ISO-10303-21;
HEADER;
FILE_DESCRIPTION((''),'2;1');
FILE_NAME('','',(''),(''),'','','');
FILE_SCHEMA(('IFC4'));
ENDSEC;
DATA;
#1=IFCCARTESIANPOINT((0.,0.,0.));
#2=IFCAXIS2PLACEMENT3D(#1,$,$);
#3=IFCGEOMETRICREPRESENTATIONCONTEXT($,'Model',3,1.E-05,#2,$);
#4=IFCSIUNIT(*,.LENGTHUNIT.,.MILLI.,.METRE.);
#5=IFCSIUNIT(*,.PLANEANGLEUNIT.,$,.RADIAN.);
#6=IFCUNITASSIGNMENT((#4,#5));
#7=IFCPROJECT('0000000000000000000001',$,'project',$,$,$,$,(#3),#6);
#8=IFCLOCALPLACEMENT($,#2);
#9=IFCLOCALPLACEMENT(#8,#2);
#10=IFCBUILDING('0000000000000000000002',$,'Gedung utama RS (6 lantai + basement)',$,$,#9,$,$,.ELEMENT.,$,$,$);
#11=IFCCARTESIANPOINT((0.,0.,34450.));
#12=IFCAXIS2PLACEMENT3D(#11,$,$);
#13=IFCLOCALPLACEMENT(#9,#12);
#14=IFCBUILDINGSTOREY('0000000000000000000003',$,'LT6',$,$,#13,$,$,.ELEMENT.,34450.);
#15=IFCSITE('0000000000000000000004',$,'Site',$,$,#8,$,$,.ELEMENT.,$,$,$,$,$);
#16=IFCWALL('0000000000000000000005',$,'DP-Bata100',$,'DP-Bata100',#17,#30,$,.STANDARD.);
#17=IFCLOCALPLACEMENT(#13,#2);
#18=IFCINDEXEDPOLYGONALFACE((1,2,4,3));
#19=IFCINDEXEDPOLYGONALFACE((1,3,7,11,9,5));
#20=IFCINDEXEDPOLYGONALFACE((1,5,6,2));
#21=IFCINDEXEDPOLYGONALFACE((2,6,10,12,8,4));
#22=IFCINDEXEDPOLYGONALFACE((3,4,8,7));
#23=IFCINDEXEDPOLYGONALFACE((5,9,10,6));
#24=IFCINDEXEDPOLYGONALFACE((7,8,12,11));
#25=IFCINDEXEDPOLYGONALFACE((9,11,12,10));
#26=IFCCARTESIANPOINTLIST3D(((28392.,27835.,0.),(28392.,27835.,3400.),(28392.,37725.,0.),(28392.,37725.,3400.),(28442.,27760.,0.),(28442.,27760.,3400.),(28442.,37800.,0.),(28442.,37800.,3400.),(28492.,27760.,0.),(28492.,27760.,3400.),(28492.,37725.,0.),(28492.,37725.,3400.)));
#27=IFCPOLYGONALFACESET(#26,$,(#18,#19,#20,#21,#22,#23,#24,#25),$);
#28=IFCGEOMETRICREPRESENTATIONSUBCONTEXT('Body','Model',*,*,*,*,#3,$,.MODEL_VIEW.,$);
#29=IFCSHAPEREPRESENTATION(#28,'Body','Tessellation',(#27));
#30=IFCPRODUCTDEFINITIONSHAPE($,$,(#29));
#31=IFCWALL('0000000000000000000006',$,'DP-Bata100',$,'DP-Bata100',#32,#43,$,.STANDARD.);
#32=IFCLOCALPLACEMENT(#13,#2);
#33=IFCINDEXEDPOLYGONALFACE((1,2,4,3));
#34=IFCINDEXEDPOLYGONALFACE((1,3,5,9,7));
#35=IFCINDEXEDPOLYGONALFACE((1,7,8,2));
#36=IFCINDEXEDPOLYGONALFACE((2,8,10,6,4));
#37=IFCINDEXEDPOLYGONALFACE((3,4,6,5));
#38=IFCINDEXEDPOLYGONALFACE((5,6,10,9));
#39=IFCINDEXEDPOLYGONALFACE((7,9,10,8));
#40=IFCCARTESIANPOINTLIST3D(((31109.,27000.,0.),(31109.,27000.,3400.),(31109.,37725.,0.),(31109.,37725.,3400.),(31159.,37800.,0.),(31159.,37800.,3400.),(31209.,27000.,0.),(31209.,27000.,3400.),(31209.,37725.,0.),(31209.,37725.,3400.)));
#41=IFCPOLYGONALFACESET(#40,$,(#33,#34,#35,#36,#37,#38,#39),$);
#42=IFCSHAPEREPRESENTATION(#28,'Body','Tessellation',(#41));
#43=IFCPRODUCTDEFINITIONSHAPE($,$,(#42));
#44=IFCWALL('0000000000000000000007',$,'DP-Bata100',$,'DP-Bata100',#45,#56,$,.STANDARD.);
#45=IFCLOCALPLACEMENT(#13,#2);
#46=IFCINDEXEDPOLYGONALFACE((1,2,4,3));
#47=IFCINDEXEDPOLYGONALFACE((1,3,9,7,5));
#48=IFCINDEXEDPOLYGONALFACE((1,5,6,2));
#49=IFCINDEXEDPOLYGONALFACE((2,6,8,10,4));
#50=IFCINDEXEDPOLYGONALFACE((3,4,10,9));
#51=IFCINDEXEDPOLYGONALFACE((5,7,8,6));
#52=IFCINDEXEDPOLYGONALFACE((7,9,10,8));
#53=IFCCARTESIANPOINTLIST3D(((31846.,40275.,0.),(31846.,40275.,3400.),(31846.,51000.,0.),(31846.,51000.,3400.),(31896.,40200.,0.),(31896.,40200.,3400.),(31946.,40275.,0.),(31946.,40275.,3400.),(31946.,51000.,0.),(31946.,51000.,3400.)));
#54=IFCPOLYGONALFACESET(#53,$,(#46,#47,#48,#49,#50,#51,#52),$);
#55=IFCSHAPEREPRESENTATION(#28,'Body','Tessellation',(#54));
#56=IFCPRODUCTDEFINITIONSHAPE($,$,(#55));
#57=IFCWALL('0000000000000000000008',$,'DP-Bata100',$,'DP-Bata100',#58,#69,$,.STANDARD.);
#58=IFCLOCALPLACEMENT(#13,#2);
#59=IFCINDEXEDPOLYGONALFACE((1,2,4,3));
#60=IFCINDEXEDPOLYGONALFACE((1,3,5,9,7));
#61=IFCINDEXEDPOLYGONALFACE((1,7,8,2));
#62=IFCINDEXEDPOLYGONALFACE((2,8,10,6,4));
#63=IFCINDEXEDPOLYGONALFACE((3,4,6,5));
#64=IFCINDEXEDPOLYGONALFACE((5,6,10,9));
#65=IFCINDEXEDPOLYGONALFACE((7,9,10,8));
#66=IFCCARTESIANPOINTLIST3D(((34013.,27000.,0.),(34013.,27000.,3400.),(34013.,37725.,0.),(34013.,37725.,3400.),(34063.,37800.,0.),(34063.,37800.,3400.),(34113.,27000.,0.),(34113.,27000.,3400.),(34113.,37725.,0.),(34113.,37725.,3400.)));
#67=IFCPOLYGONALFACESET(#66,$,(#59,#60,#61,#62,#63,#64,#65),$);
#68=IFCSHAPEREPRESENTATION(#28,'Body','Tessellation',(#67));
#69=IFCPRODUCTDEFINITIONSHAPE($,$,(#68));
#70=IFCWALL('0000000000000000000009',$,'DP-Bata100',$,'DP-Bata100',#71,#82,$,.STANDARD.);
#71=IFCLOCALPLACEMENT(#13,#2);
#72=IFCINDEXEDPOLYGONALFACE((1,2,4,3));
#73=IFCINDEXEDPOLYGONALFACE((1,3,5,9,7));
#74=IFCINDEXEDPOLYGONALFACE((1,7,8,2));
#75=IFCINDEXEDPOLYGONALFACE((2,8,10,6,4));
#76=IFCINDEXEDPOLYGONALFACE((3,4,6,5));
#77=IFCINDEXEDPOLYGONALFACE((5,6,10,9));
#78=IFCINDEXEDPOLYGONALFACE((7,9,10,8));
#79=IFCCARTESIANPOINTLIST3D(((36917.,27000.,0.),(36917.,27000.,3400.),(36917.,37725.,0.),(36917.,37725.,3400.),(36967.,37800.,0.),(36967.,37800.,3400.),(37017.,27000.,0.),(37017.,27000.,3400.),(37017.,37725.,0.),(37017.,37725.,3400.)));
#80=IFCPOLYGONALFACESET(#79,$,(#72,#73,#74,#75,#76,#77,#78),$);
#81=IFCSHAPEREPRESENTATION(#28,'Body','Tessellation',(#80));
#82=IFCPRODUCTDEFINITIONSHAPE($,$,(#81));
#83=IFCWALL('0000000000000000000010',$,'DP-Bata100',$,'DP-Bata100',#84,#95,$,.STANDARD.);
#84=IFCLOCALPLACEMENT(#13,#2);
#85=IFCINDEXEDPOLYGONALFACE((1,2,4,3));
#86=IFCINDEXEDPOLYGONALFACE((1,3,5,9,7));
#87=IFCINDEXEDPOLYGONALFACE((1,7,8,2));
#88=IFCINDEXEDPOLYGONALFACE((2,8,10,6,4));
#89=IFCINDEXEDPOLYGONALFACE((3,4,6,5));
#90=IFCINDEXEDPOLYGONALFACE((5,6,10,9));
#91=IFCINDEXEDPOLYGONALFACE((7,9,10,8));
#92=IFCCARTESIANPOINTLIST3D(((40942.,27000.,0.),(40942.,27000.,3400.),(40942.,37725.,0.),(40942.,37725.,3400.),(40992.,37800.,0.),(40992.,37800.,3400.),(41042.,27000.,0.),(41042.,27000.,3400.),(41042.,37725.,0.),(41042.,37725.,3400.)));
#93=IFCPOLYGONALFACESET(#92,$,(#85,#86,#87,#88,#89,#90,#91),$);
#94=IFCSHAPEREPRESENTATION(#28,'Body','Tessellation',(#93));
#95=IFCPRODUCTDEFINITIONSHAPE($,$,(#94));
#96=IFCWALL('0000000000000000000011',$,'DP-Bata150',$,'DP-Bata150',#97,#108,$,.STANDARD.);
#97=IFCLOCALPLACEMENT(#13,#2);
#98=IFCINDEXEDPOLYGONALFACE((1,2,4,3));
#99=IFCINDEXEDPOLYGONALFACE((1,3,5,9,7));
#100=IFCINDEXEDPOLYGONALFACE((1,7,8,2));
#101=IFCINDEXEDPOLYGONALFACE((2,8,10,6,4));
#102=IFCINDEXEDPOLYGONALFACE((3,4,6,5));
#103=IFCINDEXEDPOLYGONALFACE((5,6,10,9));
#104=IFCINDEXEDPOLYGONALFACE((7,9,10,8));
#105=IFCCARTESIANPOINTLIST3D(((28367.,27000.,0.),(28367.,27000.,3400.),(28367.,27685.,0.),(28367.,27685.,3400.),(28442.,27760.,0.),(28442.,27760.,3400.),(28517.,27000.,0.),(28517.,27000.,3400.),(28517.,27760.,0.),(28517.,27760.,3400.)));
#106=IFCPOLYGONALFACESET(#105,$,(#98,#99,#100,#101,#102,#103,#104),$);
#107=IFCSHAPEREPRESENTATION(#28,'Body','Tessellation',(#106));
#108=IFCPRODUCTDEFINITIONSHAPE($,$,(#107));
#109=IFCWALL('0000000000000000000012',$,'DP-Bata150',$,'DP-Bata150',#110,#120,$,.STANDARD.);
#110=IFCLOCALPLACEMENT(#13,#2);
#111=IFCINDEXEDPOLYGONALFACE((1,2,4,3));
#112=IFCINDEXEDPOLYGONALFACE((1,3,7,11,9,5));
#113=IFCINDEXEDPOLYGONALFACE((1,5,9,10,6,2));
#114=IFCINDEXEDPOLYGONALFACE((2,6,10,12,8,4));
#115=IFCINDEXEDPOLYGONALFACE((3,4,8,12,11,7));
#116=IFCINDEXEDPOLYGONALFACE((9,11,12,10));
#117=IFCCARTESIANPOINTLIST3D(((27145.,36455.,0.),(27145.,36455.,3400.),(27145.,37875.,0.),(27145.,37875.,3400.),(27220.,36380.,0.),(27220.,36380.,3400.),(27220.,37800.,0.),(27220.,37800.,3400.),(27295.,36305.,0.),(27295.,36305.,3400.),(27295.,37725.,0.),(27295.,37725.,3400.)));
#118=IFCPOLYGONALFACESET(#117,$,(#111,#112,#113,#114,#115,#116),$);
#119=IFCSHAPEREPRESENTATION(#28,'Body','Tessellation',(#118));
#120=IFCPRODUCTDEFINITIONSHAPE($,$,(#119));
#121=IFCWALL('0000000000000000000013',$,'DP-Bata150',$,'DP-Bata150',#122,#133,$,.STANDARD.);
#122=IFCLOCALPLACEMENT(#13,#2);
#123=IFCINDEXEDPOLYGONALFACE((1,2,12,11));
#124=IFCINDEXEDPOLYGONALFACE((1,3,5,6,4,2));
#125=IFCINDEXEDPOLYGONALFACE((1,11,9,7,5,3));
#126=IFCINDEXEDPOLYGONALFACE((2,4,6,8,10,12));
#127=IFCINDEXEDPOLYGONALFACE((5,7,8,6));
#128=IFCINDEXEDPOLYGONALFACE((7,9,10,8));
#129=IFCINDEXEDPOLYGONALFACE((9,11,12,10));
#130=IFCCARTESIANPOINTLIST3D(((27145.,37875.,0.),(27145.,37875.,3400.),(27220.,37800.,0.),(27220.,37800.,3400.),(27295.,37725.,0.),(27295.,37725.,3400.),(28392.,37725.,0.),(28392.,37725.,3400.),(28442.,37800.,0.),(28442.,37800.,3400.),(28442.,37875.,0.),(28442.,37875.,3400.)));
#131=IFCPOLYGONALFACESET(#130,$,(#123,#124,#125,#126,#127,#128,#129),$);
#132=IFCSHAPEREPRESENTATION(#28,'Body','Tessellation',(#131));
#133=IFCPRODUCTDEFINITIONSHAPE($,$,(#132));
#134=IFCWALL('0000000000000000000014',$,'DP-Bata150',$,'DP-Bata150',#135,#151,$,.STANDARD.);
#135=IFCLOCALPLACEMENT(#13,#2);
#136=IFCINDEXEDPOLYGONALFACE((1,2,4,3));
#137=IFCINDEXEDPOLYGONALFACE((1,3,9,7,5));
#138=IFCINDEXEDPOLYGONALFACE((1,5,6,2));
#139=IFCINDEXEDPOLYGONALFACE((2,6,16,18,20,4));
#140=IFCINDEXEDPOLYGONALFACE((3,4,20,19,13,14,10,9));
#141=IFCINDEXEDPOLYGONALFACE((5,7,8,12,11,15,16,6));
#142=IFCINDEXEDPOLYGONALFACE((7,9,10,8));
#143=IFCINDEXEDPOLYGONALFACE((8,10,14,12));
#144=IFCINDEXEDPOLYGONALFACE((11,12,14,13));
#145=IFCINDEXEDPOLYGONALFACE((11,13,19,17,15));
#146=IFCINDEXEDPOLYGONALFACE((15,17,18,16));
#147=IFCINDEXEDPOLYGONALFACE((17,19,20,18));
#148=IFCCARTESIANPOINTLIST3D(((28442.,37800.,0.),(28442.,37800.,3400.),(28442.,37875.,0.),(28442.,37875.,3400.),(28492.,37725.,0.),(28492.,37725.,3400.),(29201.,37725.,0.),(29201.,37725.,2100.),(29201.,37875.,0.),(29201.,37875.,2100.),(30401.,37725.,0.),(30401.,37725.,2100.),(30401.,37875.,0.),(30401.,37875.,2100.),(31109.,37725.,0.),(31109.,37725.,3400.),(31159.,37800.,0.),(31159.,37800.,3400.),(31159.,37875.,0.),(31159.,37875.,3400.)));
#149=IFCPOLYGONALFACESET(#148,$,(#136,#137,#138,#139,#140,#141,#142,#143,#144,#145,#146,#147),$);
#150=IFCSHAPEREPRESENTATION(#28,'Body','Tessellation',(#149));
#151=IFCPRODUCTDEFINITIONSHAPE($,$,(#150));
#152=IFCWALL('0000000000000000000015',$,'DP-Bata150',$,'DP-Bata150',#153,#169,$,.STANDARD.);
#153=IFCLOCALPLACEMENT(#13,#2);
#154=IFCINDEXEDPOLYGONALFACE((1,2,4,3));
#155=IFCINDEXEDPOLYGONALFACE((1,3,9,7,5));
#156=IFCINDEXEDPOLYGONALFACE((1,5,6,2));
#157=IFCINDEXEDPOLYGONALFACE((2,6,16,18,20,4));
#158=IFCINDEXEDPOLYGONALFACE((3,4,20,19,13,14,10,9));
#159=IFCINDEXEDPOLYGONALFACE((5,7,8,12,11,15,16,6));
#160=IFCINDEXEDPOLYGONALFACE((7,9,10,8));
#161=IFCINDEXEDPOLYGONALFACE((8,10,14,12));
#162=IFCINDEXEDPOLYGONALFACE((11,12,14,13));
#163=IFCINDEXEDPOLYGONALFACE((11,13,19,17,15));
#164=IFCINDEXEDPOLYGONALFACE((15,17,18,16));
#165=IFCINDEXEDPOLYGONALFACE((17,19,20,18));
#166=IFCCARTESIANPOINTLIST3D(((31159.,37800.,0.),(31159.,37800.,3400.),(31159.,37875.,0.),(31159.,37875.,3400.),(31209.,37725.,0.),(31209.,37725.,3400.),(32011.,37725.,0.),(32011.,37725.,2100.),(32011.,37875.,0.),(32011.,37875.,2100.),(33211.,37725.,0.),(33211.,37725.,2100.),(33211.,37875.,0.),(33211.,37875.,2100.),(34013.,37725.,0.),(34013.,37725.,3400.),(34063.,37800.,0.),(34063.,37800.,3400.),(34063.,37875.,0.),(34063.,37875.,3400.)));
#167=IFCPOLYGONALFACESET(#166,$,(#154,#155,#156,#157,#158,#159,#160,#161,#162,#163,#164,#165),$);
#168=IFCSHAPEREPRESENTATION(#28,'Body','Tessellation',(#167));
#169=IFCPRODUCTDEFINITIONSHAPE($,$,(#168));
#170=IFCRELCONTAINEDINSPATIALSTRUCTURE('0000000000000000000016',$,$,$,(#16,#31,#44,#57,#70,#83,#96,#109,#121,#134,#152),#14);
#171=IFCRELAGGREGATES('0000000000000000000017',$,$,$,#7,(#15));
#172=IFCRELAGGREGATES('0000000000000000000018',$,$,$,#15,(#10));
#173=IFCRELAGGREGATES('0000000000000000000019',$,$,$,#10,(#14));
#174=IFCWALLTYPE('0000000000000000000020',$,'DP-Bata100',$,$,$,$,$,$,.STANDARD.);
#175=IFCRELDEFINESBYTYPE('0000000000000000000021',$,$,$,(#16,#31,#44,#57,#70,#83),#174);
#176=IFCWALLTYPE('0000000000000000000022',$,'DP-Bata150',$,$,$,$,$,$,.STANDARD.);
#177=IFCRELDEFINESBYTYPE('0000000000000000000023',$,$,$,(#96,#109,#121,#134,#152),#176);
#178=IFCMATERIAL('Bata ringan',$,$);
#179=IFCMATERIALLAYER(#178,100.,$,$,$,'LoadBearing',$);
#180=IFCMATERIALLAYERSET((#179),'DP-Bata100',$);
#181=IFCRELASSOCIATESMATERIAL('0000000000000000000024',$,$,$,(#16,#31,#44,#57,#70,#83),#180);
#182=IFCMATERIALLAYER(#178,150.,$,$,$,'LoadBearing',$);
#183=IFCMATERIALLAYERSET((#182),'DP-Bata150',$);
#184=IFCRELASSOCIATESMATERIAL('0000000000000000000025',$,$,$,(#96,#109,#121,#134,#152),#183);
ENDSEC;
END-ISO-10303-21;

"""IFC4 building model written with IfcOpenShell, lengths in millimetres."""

from ifc_helpers import new_model, si_unit, frame, frame_2d, origin, place, context, subcontext, project, spatial, polyline, rectangle, outline, extrude, material, layer, layer_set, layer_usage, type_object, element, save


model = new_model("IFC4")

# Units and contexts
model_context = context("Model", 3, precision=1e-05, world=origin())
body_context = subcontext(model_context, "Body", "Model", "MODEL_VIEW")
ifc_project = project(units=[si_unit("LENGTHUNIT", "METRE", prefix="MILLI"), si_unit("PLANEANGLEUNIT", "RADIAN")], contexts=[model_context])

# Site, building, storey
site_placement = place(None, origin())
site = spatial("IfcSite", under=ifc_project, at=site_placement, Name="Site", CompositionType="ELEMENT")
building_placement = place(site_placement, origin())
building = spatial("IfcBuilding", under=site, at=building_placement, Name="Gedung utama RS (6 lantai + basement)", CompositionType="ELEMENT")
storey_placement = place(building_placement, frame((0.0, 0.0, 34450.0)))
storey = spatial("IfcBuildingStorey", under=building, at=storey_placement, Name="LT6", CompositionType="ELEMENT", Elevation=34450.0)

# Walls
ifc_material = material(Name="Bata ringan")
ifc_layer_1 = layer(ifc_material, 100.0, Category="LoadBearing")
ifc_layer_set_1 = layer_set([ifc_layer_1], Name="DP-Bata100")
ifc_layer_usage_1 = layer_usage(ifc_layer_set_1, "AXIS2", "NEGATIVE", 50.0)
wall_type_1 = type_object("IfcWallType", Name="DP-Bata100", PredefinedType="STANDARD")
wall_1_placement = place(storey_placement, frame((28442.0, 37800.0, 0.0), z_axis=(0.0, 0.0, 1.0), x_axis=(0.0, -1.0, 0.0)))
element("IfcWall", 1, at=wall_1_placement, inside=storey, type_object=wall_type_1, material=ifc_layer_usage_1, Name="DP-Bata100", ObjectType="DP-Bata100", PredefinedType="STANDARD", context=body_context, shape_type="SweptSolid", body=[
    extrude(outline(polyline([(75.0, -50.0), (0.0, 0.0), (75.0, 50.0), (10040.0, 50.0), (10040.0, 0.0), (9965.0, -50.0), (75.0, -50.0)])), origin(), (0.0, 0.0, 1.0), 3400.0),
])
wall_2_placement = place(storey_placement, frame((31159.0, 27000.0, 0.0), z_axis=(0.0, 0.0, 1.0), x_axis=(0.0, 1.0, 0.0)))
element("IfcWall", 2, at=wall_2_placement, inside=storey, type_object=wall_type_1, material=ifc_layer_usage_1, Name="DP-Bata100", ObjectType="DP-Bata100", PredefinedType="STANDARD", context=body_context, shape_type="SweptSolid", body=[
    extrude(outline(polyline([(0.0, -50.0), (0.0, 50.0), (10725.0, 50.0), (10800.0, 0.0), (10725.0, -50.0), (0.0, -50.0)])), origin(), (0.0, 0.0, 1.0), 3400.0),
])
wall_3_placement = place(storey_placement, frame((31896.0, 40200.0, 0.0), z_axis=(0.0, 0.0, 1.0), x_axis=(0.0, 1.0, 0.0)))
element("IfcWall", 3, at=wall_3_placement, inside=storey, type_object=wall_type_1, material=ifc_layer_usage_1, Name="DP-Bata100", ObjectType="DP-Bata100", PredefinedType="STANDARD", context=body_context, shape_type="SweptSolid", body=[
    extrude(outline(polyline([(75.0, -50.0), (0.0, 0.0), (75.0, 50.0), (10800.0, 50.0), (10800.0, -50.0), (75.0, -50.0)])), origin(), (0.0, 0.0, 1.0), 3400.0),
])
for number, where, z_axis, x_axis, name in (
    (4, (34063.0, 27000.0, 0.0), (0.0, 0.0, 1.0), (0.0, 1.0, 0.0), "DP-Bata100"),
    (5, (36967.0, 27000.0, 0.0), (0.0, 0.0, 1.0), (0.0, 1.0, 0.0), "DP-Bata100"),
    (6, (40992.0, 27000.0, 0.0), (0.0, 0.0, 1.0), (0.0, 1.0, 0.0), "DP-Bata100"),
):
    element("IfcWall", number, at=place(storey_placement, frame(where, z_axis=z_axis, x_axis=x_axis)), inside=storey, type_object=wall_type_1, material=ifc_layer_usage_1, Name=name, ObjectType="DP-Bata100", PredefinedType="STANDARD", context=body_context, shape_type="SweptSolid", body=[
        extrude(outline(polyline([(0.0, -50.0), (0.0, 50.0), (10725.0, 50.0), (10800.0, 0.0), (10725.0, -50.0), (0.0, -50.0)])), origin(), (0.0, 0.0, 1.0), 3400.0),
    ])
ifc_layer_2 = layer(ifc_material, 150.0, Category="LoadBearing")
ifc_layer_set_2 = layer_set([ifc_layer_2], Name="DP-Bata150")
ifc_layer_usage_2 = layer_usage(ifc_layer_set_2, "AXIS2", "NEGATIVE", 75.0)
wall_type_2 = type_object("IfcWallType", Name="DP-Bata150", PredefinedType="STANDARD")
wall_4_placement = place(storey_placement, frame((28442.0, 27760.0, 0.0), z_axis=(0.0, 0.0, 1.0), x_axis=(0.0, -1.0, 0.0)))
element("IfcWall", 7, at=wall_4_placement, inside=storey, type_object=wall_type_2, material=ifc_layer_usage_2, Name="DP-Bata150", ObjectType="DP-Bata150", PredefinedType="STANDARD", context=body_context, shape_type="SweptSolid", body=[
    extrude(outline(polyline([(75.0, -75.0), (0.0, 0.0), (0.0, 75.0), (760.0, 75.0), (760.0, -75.0), (75.0, -75.0)])), origin(), (0.0, 0.0, 1.0), 3400.0),
])
wall_5_placement = place(storey_placement, frame((27220.0, 36380.0, 0.0), z_axis=(0.0, 0.0, 1.0), x_axis=(0.0, 1.0, 0.0)))
element("IfcWall", 8, at=wall_5_placement, inside=storey, type_object=wall_type_2, material=ifc_layer_usage_2, Name="DP-Bata150", ObjectType="DP-Bata150", PredefinedType="STANDARD", context=body_context, shape_type="SweptSolid", body=[
    extrude(outline(polyline([(-75.0, -75.0), (0.0, 0.0), (75.0, 75.0), (1495.0, 75.0), (1420.0, 0.0), (1345.0, -75.0), (-75.0, -75.0)])), origin(), (0.0, 0.0, 1.0), 3400.0),
])
wall_6_placement = place(storey_placement, frame((27220.0, 37800.0, 0.0), z_axis=(0.0, 0.0, 1.0), x_axis=(1.0, 0.0, 0.0)))
element("IfcWall", 9, at=wall_6_placement, inside=storey, type_object=wall_type_2, material=ifc_layer_usage_2, Name="DP-Bata150", ObjectType="DP-Bata150", PredefinedType="STANDARD", context=body_context, shape_type="SweptSolid", body=[
    extrude(outline(polyline([(75.0, -75.0), (0.0, 0.0), (-75.0, 75.0), (1222.0, 75.0), (1222.0, 0.0), (1172.0, -75.0), (75.0, -75.0)])), origin(), (0.0, 0.0, 1.0), 3400.0),
])

# Walls, openings
wall_7_placement = place(storey_placement, frame((28442.0, 37800.0, 0.0), z_axis=(0.0, 0.0, 1.0), x_axis=(1.0, 0.0, 0.0)))
wall_7 = element("IfcWall", 10, at=wall_7_placement, inside=storey, type_object=wall_type_2, material=ifc_layer_usage_2, Name="DP-Bata150", ObjectType="DP-Bata150", PredefinedType="STANDARD", context=body_context, shape_type="SweptSolid", body=[
    extrude(outline(polyline([(50.0, -75.0), (0.0, 0.0), (0.0, 75.0), (2717.0, 75.0), (2717.0, 0.0), (2667.0, -75.0), (50.0, -75.0)])), origin(), (0.0, 0.0, 1.0), 3400.0),
])
opening_1_placement = place(wall_7_placement, frame((759.0, 0.0, 0.0), z_axis=(0.0, 0.0, 1.0), x_axis=(1.0, 0.0, 0.0)))
element("IfcOpeningElement", 11, at=opening_1_placement, cuts=wall_7, PredefinedType="OPENING", context=body_context, shape_type="SweptSolid", body=[
    extrude(rectangle(XDim=1200.0, YDim=170.0, at=frame_2d((600.0, 0.0))), origin(), (0.0, 0.0, 1.0), 2100.0),
])
wall_8_placement = place(storey_placement, frame((31159.0, 37800.0, 0.0), z_axis=(0.0, 0.0, 1.0), x_axis=(1.0, 0.0, 0.0)))
wall_8 = element("IfcWall", 12, at=wall_8_placement, inside=storey, type_object=wall_type_2, material=ifc_layer_usage_2, Name="DP-Bata150", ObjectType="DP-Bata150", PredefinedType="STANDARD", context=body_context, shape_type="SweptSolid", body=[
    extrude(outline(polyline([(50.0, -75.0), (0.0, 0.0), (0.0, 75.0), (2904.0, 75.0), (2904.0, 0.0), (2854.0, -75.0), (50.0, -75.0)])), origin(), (0.0, 0.0, 1.0), 3400.0),
])
opening_2_placement = place(wall_8_placement, frame((852.0, 0.0, 0.0), z_axis=(0.0, 0.0, 1.0), x_axis=(1.0, 0.0, 0.0)))
element("IfcOpeningElement", 13, at=opening_2_placement, cuts=wall_8, PredefinedType="OPENING", context=body_context, shape_type="SweptSolid", body=[
    extrude(rectangle(XDim=1200.0, YDim=170.0, at=frame_2d((600.0, 0.0))), origin(), (0.0, 0.0, 1.0), 2100.0),
])

save(model, "model.ifc")
